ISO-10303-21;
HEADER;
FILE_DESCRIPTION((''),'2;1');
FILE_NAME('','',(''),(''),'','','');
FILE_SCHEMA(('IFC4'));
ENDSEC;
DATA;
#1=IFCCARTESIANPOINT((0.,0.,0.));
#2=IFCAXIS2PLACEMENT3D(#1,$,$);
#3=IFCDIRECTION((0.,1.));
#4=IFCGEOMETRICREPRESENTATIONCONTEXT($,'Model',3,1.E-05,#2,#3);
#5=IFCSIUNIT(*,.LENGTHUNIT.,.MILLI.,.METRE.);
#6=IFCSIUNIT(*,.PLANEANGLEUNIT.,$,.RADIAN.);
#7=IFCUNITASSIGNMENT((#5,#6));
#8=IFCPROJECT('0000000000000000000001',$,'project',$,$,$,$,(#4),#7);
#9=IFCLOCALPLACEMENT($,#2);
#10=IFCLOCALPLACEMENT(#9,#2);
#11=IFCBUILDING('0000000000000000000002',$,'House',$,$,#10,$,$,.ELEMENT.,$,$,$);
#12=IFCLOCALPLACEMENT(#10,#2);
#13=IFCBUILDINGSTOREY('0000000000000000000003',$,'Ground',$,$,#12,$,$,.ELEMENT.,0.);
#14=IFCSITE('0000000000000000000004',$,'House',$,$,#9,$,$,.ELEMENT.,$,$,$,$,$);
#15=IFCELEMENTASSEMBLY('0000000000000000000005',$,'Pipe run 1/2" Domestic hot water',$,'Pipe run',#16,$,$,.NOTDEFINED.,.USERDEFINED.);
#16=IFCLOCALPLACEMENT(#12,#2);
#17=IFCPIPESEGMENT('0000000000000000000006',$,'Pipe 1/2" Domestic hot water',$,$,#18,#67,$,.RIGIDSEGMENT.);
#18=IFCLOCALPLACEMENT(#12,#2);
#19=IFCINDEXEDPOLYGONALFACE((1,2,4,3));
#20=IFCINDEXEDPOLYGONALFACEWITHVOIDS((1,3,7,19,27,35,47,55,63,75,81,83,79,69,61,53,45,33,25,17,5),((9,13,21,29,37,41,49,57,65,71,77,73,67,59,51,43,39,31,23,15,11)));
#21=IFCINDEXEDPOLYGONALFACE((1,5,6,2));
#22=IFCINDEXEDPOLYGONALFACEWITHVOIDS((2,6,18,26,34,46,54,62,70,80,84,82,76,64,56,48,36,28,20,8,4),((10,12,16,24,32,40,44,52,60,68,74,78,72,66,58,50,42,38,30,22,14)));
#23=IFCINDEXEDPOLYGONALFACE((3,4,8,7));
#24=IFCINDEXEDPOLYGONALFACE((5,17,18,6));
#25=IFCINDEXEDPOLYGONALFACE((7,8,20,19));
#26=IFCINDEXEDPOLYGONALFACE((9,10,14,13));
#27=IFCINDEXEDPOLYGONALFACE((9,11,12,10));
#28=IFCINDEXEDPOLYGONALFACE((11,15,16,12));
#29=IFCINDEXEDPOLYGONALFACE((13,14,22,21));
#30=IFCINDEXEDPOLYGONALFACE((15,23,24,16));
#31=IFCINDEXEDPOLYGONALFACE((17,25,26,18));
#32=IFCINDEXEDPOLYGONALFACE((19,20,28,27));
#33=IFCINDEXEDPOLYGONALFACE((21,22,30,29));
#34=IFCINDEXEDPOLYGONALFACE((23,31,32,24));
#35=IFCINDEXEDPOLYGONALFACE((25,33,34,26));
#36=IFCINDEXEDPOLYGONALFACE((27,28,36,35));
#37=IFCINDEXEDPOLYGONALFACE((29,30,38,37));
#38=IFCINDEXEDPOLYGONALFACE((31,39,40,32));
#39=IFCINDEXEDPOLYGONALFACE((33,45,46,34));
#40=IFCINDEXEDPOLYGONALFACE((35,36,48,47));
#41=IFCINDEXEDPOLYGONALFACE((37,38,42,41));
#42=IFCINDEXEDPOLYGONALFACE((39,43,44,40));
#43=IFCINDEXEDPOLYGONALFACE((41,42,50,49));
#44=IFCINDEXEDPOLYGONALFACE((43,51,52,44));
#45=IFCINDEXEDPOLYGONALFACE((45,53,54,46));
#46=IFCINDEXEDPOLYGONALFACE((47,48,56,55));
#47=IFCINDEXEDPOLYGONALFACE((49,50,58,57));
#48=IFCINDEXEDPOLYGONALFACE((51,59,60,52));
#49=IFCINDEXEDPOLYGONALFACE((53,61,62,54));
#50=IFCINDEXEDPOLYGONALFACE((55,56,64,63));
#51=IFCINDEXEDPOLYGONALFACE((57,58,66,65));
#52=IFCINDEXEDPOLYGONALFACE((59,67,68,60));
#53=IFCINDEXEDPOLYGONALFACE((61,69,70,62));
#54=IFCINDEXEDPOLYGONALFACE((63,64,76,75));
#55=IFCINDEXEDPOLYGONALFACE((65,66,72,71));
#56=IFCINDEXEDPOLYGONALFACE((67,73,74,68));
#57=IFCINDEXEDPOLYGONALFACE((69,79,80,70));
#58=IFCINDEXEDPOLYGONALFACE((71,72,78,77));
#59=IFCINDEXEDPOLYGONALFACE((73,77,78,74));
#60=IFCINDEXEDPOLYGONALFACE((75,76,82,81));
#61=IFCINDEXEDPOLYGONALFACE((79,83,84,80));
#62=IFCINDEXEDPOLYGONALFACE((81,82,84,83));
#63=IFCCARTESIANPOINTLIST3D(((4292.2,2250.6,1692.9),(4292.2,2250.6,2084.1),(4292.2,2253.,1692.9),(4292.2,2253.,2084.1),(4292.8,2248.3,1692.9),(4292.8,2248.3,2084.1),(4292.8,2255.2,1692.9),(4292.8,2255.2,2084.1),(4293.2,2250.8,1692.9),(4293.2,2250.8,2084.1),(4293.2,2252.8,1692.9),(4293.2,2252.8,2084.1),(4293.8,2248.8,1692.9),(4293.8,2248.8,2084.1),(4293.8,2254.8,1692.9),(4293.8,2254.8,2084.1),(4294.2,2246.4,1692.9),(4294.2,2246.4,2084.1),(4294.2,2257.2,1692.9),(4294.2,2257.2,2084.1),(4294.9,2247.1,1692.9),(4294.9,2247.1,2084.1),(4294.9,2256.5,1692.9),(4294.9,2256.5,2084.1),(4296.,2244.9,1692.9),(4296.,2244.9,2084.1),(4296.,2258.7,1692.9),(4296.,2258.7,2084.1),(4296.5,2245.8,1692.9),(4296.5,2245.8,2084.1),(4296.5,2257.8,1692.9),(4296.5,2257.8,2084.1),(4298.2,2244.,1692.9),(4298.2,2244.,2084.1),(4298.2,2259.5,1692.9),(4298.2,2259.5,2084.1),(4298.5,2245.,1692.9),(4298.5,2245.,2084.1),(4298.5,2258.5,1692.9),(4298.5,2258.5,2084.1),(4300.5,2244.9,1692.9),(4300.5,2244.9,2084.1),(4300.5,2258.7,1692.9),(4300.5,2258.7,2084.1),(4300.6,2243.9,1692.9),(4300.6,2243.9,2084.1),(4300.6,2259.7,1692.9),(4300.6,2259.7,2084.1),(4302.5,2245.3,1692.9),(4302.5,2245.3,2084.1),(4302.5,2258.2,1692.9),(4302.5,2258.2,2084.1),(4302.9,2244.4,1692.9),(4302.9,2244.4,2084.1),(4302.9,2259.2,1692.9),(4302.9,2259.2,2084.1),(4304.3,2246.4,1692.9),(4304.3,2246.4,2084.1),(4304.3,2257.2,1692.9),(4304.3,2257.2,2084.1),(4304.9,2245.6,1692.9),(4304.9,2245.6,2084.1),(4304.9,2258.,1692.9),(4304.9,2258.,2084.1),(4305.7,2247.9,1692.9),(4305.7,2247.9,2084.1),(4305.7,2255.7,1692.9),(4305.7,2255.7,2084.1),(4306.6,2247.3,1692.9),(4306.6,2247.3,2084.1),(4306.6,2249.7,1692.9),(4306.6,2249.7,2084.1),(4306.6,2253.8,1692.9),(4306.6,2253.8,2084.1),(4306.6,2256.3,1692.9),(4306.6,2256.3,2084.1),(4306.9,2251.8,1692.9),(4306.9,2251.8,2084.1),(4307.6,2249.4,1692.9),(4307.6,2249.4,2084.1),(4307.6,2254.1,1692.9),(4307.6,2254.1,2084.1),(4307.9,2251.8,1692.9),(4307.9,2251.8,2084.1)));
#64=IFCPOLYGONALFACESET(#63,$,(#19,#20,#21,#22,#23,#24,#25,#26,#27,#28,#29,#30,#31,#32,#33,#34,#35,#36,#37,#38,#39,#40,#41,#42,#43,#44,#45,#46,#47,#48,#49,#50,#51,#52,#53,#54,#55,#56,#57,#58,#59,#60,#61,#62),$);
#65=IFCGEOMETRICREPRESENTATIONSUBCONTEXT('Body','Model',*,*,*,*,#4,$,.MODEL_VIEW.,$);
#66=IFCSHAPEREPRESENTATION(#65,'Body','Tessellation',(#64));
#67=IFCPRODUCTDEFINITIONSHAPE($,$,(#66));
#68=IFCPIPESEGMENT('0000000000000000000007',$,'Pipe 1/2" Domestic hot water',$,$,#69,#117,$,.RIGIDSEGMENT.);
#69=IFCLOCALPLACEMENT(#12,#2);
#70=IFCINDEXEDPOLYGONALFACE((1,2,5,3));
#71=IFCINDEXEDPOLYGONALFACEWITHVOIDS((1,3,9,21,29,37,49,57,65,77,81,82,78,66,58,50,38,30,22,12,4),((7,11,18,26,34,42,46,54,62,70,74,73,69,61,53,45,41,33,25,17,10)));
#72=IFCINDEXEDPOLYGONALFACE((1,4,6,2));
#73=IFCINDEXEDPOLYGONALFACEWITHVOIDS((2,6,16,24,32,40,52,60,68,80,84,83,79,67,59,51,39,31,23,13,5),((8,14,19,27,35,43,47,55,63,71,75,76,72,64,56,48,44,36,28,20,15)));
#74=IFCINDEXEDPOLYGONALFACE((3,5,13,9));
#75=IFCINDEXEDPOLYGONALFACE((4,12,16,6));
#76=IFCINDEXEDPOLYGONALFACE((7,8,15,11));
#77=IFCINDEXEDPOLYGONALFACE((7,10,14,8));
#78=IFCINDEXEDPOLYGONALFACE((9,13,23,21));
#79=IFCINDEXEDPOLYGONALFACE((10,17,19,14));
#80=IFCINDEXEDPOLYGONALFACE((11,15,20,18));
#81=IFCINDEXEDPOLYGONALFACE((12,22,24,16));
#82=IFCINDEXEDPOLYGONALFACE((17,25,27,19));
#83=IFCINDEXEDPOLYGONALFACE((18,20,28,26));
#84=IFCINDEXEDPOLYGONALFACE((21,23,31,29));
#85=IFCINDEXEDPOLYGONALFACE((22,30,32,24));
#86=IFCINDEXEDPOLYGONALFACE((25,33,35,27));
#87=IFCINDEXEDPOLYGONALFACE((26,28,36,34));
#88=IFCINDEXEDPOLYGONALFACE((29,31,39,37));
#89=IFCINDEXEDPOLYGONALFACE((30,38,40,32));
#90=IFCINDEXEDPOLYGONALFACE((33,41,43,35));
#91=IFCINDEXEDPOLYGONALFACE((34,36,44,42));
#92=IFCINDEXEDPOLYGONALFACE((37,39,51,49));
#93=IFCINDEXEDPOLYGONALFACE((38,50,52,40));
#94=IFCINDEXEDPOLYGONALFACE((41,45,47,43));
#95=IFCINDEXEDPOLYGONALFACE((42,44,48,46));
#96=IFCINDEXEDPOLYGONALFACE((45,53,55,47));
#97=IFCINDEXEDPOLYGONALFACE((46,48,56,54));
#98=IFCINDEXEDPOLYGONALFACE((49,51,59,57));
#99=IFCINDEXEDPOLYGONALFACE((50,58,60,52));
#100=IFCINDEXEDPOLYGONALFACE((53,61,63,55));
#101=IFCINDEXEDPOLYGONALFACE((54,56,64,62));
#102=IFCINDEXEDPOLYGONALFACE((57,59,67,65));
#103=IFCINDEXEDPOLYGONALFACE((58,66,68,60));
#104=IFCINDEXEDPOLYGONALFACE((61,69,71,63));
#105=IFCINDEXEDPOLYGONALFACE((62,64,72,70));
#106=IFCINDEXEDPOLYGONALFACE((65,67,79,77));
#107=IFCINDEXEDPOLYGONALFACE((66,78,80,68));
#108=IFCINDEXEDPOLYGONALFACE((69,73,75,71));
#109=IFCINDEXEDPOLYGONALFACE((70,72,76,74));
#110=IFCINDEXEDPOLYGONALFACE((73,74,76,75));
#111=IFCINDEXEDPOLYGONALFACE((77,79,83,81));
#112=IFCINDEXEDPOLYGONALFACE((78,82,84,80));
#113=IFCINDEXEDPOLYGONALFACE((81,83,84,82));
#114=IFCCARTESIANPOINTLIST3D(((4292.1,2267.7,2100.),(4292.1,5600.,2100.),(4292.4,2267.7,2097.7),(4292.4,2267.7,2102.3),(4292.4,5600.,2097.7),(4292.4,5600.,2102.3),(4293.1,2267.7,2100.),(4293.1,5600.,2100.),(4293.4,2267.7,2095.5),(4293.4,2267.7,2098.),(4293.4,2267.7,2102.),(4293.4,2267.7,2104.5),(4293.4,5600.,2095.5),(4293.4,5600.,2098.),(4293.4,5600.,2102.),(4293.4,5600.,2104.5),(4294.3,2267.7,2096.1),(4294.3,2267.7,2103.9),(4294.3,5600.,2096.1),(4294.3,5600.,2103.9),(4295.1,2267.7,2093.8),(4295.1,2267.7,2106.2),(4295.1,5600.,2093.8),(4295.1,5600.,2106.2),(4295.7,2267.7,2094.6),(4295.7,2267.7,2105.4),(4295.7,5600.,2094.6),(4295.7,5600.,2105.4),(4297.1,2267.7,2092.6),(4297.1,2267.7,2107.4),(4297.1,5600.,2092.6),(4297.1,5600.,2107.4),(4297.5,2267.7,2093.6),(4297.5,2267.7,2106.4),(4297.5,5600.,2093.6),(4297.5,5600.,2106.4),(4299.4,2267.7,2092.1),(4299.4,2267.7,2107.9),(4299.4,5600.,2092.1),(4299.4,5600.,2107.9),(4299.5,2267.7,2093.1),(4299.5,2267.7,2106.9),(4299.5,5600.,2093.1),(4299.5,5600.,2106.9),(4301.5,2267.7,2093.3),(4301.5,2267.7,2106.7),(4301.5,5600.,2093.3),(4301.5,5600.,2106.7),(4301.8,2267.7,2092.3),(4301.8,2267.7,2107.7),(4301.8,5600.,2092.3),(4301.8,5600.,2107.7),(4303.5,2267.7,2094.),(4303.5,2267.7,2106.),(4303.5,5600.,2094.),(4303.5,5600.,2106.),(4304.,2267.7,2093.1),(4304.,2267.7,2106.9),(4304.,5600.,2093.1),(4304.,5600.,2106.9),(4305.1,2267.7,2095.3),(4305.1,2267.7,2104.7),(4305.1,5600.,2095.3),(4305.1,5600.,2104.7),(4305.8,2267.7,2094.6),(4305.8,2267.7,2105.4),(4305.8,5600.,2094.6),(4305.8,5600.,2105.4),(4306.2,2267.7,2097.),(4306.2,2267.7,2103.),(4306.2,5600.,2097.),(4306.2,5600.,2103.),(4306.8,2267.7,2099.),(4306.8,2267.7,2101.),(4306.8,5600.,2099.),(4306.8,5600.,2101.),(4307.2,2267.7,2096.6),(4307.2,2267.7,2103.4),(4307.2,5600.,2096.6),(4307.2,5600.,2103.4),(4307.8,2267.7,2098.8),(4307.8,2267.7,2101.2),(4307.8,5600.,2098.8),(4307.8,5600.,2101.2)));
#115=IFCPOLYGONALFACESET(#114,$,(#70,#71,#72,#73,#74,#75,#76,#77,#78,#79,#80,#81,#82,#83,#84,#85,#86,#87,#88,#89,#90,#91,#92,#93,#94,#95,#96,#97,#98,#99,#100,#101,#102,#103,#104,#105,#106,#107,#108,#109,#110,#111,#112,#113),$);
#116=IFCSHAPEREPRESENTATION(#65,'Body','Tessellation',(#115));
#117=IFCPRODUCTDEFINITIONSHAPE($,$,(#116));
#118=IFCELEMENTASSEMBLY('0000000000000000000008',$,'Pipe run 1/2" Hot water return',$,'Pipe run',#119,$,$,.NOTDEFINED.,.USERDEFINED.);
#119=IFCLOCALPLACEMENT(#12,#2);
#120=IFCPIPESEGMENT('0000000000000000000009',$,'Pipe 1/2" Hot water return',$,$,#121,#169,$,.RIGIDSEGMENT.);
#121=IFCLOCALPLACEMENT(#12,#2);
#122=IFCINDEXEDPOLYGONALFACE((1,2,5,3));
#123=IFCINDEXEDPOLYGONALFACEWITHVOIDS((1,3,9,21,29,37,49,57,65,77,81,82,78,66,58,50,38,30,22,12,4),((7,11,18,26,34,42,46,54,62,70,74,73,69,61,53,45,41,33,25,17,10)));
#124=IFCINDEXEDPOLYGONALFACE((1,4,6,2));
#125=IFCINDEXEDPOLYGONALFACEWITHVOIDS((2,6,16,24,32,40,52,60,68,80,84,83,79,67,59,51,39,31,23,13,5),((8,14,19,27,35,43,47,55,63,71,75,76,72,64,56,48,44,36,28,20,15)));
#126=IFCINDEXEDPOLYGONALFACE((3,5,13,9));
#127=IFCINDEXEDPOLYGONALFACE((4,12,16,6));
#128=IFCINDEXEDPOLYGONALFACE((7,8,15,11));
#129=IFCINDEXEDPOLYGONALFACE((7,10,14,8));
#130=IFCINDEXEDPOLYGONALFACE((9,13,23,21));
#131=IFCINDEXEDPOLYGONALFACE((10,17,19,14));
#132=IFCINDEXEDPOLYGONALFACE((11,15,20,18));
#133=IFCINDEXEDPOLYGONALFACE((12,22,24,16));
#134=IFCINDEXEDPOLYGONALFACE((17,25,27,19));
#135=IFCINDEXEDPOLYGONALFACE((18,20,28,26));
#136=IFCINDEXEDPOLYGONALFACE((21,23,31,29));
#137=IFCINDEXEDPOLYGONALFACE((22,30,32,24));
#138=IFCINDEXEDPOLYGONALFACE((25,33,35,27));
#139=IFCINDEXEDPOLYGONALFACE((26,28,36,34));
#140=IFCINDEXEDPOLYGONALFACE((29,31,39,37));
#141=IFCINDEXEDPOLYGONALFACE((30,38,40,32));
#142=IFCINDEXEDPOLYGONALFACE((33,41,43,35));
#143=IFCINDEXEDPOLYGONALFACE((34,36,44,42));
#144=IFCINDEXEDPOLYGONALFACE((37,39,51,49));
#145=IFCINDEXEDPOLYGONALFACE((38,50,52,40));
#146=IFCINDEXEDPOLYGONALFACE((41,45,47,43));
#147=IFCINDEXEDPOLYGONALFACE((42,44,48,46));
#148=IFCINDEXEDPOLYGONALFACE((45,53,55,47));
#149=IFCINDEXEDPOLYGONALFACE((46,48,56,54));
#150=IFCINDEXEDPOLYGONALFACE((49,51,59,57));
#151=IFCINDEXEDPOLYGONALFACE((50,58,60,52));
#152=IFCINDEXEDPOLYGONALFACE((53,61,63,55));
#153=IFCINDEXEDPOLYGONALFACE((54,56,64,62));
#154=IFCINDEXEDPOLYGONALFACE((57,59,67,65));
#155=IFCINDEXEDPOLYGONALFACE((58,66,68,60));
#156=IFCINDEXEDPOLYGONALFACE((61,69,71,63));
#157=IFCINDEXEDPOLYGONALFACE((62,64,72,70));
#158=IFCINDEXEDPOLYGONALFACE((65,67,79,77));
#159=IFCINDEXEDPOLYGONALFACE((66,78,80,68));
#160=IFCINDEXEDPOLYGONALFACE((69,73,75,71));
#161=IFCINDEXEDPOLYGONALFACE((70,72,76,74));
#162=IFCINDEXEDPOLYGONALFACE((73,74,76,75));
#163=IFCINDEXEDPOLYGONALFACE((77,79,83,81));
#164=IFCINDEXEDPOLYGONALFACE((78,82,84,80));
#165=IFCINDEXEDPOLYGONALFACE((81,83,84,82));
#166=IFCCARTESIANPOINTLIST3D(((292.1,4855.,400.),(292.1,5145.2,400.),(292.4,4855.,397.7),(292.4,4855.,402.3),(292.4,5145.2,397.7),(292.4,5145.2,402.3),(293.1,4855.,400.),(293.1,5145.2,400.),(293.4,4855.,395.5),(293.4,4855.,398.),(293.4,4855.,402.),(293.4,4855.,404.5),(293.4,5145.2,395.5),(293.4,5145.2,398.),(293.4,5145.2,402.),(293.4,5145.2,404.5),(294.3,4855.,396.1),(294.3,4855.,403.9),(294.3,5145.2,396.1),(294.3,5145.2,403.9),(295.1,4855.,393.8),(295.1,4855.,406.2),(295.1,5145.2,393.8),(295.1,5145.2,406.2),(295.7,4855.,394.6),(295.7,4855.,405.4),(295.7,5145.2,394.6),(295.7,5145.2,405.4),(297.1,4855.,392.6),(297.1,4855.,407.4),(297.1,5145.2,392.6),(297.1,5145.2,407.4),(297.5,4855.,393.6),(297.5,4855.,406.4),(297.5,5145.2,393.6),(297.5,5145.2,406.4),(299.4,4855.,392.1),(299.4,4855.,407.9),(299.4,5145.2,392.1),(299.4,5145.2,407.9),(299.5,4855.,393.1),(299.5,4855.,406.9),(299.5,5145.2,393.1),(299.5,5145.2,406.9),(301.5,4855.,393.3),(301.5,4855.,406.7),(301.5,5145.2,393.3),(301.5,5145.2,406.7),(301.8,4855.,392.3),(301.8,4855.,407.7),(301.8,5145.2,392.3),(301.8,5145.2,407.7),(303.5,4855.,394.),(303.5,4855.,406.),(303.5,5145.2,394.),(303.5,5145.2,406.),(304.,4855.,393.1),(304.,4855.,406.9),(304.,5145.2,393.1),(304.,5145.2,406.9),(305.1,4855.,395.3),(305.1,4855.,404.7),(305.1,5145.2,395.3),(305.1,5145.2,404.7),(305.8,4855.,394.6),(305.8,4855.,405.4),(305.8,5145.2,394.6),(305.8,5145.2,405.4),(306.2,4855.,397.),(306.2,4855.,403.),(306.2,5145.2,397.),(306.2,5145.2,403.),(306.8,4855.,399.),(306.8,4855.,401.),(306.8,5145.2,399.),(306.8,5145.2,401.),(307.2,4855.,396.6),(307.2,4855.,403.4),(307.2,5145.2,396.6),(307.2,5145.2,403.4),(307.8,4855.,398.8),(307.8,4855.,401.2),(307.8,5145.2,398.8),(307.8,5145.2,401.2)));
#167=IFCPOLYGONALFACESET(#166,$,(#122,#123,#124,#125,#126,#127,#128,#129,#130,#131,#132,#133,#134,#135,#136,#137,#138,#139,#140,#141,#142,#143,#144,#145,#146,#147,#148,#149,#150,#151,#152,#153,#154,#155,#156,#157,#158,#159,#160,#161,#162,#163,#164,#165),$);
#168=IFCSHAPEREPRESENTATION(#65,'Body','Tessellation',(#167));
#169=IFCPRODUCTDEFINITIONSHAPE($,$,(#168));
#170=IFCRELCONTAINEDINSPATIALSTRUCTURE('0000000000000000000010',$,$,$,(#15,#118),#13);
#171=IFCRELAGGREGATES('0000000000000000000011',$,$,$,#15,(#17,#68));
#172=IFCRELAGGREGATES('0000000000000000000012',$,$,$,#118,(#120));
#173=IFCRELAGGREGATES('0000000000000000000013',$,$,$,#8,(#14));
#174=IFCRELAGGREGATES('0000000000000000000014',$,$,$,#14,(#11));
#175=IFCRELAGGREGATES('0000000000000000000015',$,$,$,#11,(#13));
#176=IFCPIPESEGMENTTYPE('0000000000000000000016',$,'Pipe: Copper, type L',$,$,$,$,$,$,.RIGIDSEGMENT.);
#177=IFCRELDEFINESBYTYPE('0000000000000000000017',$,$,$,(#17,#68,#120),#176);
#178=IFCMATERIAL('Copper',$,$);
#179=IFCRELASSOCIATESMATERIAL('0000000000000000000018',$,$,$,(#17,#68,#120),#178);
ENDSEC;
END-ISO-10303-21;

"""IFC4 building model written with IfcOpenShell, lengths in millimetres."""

from ifc_helpers import new_model, si_unit, direction, frame, origin, origin_with_axes, origin_2d, place, context, subcontext, project, spatial, hollow_circle, extrude, material, type_object, element, aggregate, save


model = new_model("IFC4")

# Units and contexts
model_context = context("Model", 3, precision=1e-05, world=origin(), true_north=direction((0.0, 1.0)))
body_context = subcontext(model_context, "Body", "Model", "MODEL_VIEW")
ifc_project = project(units=[si_unit("LENGTHUNIT", "METRE", prefix="MILLI"), si_unit("PLANEANGLEUNIT", "RADIAN")], contexts=[model_context])

# Site, building, storey
site_placement = place(None, origin())
site = spatial("IfcSite", under=ifc_project, at=site_placement, Name="House", CompositionType="ELEMENT")
building_placement = place(site_placement, origin())
building = spatial("IfcBuilding", under=site, at=building_placement, Name="House", CompositionType="ELEMENT")
storey_placement = place(building_placement, origin())
storey = spatial("IfcBuildingStorey", under=building, at=storey_placement, Name="Ground", CompositionType="ELEMENT", Elevation=0.0)

# Element assemblies, pipe segments
assembly_1_placement = place(storey_placement, origin_with_axes())
assembly_1 = element("IfcElementAssembly", 1, at=assembly_1_placement, inside=storey, Name="Pipe run 1/2\" Domestic hot water", ObjectType="Pipe run", AssemblyPlace="NOTDEFINED", PredefinedType="USERDEFINED")
ifc_material = material(Name="Copper")
pipe_segment_type = type_object("IfcPipeSegmentType", Name="Pipe: Copper, type L", PredefinedType="RIGIDSEGMENT")
pipe_segment_1_placement = place(storey_placement, origin_with_axes())
pipe_segment_1 = element("IfcPipeSegment", 2, at=pipe_segment_1_placement, type_object=pipe_segment_type, material=ifc_material, Name="Pipe 1/2\" Domestic hot water", PredefinedType="RIGIDSEGMENT", context=body_context, shape_type="SweptSolid", body=[
    extrude(hollow_circle(Radius=7.9, WallThickness=1.0, at=origin_2d()), frame((4300.0, 2251.8, 1692.9), z_axis=(0.0, 0.0, 1.0), x_axis=(1.0, 0.0, 0.0)), (0.0, 0.0, 1.0), 391.3),
])
pipe_segment_2_placement = place(storey_placement, origin_with_axes())
pipe_segment_2 = element("IfcPipeSegment", 3, at=pipe_segment_2_placement, type_object=pipe_segment_type, material=ifc_material, Name="Pipe 1/2\" Domestic hot water", PredefinedType="RIGIDSEGMENT", context=body_context, shape_type="SweptSolid", body=[
    extrude(hollow_circle(Radius=7.9, WallThickness=1.0, at=origin_2d()), frame((4300.0, 2267.7, 2100.0), z_axis=(0.0, 1.0, 0.0), x_axis=(-1.0, 0.0, 0.0)), (0.0, 0.0, 1.0), 3332.3),
])
assembly_2_placement = place(storey_placement, origin_with_axes())
assembly_2 = element("IfcElementAssembly", 4, at=assembly_2_placement, inside=storey, Name="Pipe run 1/2\" Hot water return", ObjectType="Pipe run", AssemblyPlace="NOTDEFINED", PredefinedType="USERDEFINED")
pipe_segment_3_placement = place(storey_placement, origin_with_axes())
pipe_segment_3 = element("IfcPipeSegment", 5, at=pipe_segment_3_placement, type_object=pipe_segment_type, material=ifc_material, Name="Pipe 1/2\" Hot water return", PredefinedType="RIGIDSEGMENT", context=body_context, shape_type="SweptSolid", body=[
    extrude(hollow_circle(Radius=7.9, WallThickness=1.0, at=origin_2d()), frame((300.0, 4855.0, 400.0), z_axis=(0.0, 1.0, 0.0), x_axis=(-1.0, 0.0, 0.0)), (0.0, 0.0, 1.0), 290.2),
])

aggregate(assembly_1, [pipe_segment_1, pipe_segment_2])

aggregate(assembly_2, [pipe_segment_3])

save(model, "model.ifc")
